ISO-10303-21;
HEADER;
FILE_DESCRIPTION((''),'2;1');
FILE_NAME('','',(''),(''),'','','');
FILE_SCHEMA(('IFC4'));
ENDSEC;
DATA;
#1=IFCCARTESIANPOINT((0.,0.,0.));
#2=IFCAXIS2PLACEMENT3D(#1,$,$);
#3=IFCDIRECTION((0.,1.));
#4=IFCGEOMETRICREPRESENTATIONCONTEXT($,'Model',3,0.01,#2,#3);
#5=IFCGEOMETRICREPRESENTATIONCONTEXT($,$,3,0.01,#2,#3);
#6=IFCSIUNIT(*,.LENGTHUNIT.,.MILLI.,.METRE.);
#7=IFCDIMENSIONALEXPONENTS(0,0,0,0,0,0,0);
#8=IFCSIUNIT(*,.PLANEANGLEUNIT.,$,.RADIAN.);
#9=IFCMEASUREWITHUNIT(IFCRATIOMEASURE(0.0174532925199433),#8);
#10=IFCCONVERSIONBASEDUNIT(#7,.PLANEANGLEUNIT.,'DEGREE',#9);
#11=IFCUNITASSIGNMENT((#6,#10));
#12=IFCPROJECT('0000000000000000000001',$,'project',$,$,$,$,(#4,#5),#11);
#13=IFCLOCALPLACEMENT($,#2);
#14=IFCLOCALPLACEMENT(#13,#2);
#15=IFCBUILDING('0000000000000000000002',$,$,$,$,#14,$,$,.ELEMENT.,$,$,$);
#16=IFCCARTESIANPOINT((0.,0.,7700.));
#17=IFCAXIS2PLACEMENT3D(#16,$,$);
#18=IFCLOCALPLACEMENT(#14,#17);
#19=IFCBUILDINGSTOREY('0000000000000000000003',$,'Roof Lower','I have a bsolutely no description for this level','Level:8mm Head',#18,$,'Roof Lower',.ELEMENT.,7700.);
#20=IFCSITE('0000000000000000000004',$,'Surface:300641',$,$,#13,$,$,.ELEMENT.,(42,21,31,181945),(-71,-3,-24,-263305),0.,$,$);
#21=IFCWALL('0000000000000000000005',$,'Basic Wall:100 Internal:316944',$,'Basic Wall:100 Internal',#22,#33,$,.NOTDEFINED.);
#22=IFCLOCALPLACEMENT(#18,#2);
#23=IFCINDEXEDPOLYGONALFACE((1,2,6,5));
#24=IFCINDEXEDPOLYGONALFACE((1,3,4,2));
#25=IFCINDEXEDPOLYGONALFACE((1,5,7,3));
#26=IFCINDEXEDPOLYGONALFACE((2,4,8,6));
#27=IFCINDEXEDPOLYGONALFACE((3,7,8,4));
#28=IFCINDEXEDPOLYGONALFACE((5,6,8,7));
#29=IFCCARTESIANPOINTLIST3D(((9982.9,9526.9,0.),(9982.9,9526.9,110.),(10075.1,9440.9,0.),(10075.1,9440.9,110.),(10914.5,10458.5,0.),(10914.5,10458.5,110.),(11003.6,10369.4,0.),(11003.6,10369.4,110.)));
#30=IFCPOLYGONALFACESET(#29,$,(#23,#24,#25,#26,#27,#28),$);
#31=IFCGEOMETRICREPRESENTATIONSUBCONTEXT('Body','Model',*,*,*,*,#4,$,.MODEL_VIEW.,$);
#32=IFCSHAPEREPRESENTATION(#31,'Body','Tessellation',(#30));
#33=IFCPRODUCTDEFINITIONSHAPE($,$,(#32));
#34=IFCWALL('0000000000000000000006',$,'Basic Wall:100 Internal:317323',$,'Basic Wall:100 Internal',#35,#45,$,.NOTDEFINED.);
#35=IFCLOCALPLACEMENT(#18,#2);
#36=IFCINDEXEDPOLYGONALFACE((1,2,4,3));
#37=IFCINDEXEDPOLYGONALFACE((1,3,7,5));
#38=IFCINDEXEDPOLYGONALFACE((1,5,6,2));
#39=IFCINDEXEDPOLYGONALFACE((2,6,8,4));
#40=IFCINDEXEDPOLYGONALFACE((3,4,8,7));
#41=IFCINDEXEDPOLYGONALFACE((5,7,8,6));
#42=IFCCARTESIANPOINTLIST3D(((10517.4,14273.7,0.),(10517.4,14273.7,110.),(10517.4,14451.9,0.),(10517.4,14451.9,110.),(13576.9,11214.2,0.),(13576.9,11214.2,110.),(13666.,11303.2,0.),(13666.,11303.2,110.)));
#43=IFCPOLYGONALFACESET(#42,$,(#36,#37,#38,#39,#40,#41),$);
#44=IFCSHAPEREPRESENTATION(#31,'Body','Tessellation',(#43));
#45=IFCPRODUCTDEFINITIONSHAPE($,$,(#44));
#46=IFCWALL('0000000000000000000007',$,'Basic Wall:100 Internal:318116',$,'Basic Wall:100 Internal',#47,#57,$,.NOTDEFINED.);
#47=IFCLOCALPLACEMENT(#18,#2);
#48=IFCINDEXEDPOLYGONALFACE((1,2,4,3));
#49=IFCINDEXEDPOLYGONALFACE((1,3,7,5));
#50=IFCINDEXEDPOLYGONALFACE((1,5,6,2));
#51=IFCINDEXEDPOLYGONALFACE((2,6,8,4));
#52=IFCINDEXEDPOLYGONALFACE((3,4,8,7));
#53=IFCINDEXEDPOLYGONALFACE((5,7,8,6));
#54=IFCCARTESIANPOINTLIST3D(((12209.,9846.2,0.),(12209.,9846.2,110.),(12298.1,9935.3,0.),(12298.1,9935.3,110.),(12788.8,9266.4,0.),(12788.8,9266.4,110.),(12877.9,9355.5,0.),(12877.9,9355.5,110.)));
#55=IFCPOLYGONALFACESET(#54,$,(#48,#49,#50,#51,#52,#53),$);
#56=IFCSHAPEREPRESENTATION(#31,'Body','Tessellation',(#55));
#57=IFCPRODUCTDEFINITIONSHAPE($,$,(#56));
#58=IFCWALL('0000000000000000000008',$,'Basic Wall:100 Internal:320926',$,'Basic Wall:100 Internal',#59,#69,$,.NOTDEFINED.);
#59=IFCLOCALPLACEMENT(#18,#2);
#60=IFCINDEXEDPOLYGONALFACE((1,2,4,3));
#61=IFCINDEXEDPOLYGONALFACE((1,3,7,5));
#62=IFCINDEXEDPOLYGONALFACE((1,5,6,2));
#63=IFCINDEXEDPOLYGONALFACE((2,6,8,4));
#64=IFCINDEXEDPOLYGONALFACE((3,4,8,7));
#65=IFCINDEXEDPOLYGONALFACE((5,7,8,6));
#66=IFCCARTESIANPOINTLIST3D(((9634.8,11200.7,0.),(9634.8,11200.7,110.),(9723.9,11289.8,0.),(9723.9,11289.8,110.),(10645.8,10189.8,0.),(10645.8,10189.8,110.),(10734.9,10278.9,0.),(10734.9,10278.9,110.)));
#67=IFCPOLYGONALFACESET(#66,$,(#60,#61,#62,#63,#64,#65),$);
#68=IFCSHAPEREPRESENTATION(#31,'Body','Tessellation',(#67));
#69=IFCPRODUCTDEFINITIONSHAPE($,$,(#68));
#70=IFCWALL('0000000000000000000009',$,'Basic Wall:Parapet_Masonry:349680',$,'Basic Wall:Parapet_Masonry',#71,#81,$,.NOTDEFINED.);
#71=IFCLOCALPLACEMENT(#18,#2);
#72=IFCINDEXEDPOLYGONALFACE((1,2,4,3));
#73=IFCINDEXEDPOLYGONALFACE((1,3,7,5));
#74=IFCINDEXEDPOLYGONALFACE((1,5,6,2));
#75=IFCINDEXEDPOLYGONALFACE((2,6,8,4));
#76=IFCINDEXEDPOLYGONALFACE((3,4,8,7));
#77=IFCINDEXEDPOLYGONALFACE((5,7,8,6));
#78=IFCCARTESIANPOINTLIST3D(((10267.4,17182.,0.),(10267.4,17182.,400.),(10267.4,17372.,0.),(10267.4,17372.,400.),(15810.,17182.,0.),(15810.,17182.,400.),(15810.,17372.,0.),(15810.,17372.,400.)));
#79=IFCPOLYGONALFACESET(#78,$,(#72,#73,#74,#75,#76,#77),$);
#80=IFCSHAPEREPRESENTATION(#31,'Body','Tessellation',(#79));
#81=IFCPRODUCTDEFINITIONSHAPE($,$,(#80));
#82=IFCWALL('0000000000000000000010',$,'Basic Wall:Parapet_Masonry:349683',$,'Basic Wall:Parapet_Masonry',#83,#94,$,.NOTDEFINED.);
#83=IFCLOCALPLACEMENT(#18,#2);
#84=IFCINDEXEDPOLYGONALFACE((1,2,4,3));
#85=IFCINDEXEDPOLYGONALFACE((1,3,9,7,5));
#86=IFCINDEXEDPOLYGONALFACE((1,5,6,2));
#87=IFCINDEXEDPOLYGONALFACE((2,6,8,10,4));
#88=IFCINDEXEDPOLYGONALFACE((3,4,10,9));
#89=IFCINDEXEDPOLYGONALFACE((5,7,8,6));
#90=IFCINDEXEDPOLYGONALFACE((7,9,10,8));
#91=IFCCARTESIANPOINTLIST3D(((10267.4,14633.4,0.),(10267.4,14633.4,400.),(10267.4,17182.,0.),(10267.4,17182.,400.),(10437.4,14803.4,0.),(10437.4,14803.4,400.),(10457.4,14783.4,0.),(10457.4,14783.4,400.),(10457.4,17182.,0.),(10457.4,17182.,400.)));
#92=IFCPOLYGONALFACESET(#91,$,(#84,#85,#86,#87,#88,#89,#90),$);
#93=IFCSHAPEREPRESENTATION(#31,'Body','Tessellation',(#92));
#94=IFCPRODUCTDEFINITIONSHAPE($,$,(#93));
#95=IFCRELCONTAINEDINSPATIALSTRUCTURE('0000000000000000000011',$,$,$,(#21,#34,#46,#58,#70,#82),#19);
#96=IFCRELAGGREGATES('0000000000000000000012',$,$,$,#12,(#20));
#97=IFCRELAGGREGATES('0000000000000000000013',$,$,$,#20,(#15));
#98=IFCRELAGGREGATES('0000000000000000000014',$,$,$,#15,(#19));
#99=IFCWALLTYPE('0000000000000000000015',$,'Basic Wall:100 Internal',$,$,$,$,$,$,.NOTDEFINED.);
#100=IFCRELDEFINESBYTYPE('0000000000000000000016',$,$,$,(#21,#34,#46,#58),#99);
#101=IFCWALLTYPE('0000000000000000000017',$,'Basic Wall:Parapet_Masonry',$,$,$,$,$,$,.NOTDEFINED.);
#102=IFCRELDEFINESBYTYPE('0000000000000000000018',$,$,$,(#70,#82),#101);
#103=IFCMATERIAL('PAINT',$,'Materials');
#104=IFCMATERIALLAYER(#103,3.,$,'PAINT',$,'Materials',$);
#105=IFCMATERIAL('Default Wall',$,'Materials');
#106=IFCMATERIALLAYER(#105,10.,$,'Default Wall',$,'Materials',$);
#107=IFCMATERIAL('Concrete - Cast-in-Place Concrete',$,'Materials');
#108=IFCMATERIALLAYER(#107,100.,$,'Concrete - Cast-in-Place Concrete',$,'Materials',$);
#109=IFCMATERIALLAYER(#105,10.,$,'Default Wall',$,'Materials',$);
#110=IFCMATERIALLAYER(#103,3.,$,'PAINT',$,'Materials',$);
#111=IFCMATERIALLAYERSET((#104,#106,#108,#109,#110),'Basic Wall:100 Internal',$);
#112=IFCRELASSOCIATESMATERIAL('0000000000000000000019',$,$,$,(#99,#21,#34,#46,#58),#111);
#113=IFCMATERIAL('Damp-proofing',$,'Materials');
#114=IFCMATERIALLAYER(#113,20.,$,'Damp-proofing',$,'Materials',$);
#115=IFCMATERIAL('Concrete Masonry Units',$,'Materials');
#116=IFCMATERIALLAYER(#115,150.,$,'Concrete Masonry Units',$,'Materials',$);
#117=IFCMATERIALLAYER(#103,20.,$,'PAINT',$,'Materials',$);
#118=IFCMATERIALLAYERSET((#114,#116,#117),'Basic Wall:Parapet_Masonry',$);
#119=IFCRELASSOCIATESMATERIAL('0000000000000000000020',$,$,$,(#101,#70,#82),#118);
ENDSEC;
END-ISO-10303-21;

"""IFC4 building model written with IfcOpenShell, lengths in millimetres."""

from ifc_helpers import new_model, entity, si_unit, converted_unit, direction, frame, frame_2d, origin, place, context, subcontext, project, spatial, polyline, rectangle, outline, extrude, clip, halfspace, bounded_halfspace, material, layer, layer_set, layer_usage, type_object, element, save


model = new_model("IFC4")

# Units and contexts
model_context = context("Model", 3, precision=0.01, world=origin(), true_north=direction((0.0, 1.0)))
context_of_model = context(None, 3, precision=0.01, world=origin(), true_north=direction((0.0, 1.0)))
body_context = subcontext(model_context, "Body", "Model", "MODEL_VIEW")
ifc_project = project(units=[si_unit("LENGTHUNIT", "METRE", prefix="MILLI"), converted_unit("PLANEANGLEUNIT", "DEGREE", entity("IfcRatioMeasure", 0.0174532925199433), si_unit("PLANEANGLEUNIT", "RADIAN"), dimensions=[0, 0, 0, 0, 0, 0, 0])], contexts=[model_context, context_of_model])

# Site, building, storey
site_placement = place(None, origin())
site = spatial("IfcSite", under=ifc_project, at=site_placement, Name="Surface:300641", CompositionType="ELEMENT", RefLatitude=(42, 21, 31, 181945), RefLongitude=(-71, -3, -24, -263305), RefElevation=0.0)
building_placement = place(site_placement, origin())
building = spatial("IfcBuilding", under=site, at=building_placement, CompositionType="ELEMENT")
storey_placement = place(building_placement, frame((0.0, 0.0, 7700.0)))
storey = spatial("IfcBuildingStorey", under=building, at=storey_placement, Name="Roof Lower", Description="I have a bsolutely no description for this level", ObjectType="Level:8mm Head", LongName="Roof Lower", CompositionType="ELEMENT", Elevation=7700.0)

# Shared definitions
ifc_material_1 = material(Name="Concrete - Cast-in-Place Concrete", Category="Materials")

# Walls
ifc_material_2 = material(Name="PAINT", Category="Materials")
ifc_material_3 = material(Name="Default Wall", Category="Materials")
ifc_layer_1 = layer(ifc_material_2, 3.0, Name="PAINT", Category="Materials")
ifc_layer_2 = layer(ifc_material_3, 10.0, Name="Default Wall", Category="Materials")
ifc_layer_3 = layer(ifc_material_1, 100.0, Name="Concrete - Cast-in-Place Concrete", Category="Materials")
ifc_layer_4 = layer(ifc_material_3, 10.0, Name="Default Wall", Category="Materials")
ifc_layer_5 = layer(ifc_material_2, 3.0, Name="PAINT", Category="Materials")
ifc_layer_set_1 = layer_set([ifc_layer_1, ifc_layer_2, ifc_layer_3, ifc_layer_4, ifc_layer_5], Name="Basic Wall:100 Internal")
wall_type_1 = type_object("IfcWallType", Name="Basic Wall:100 Internal", PredefinedType="NOTDEFINED", material=ifc_layer_set_1)
ifc_layer_usage_1 = layer_usage(ifc_layer_set_1, "AXIS2", "NEGATIVE", 63.0)
wall_1_placement = place(storey_placement, frame((10959.0, 10413.9, 0.0), z_axis=(0.0, 0.0, 1.0), x_axis=(-0.707107, -0.707107, 0.0)))
element("IfcWall", 1, at=wall_1_placement, inside=storey, type_object=wall_type_1, material=ifc_layer_usage_1, Name="Basic Wall:100 Internal:316944", ObjectType="Basic Wall:100 Internal", PredefinedType="NOTDEFINED", context=body_context, shape_type="Clipping", body=[
    clip(clip(extrude(outline(polyline([(0.0, -63.0), (254.0, -63.0), (380.0, -63.0), (1317.4, -63.0), (1313.0, 63.0), (0.0, 63.0), (0.0, -63.0)])), origin(), (0.0, 0.0, 1.0), 110.0), bounded_halfspace(frame((0.0, -63.0, 110.0), z_axis=(0.0, 0.0, -1.0), x_axis=(-0.707107, 0.707107, 0.0)), True, frame((0.0, -63.0, 110.0)), polyline([(0.0, 0.0), (254.0, 0.0), (380.0, 0.0), (1317.4, 0.0), (1313.0, 126.0), (0.0, 126.0), (0.0, 0.0)]))), halfspace(frame((0.0, 0.0, -3500.0)), True)),
])
ifc_layer_usage_2 = layer_usage(ifc_layer_set_1, "AXIS2", "NEGATIVE", 63.0)
wall_2_placement = place(storey_placement, frame((10472.8, 14407.3, 0.0), z_axis=(0.0, 0.0, 1.0), x_axis=(0.707107, -0.707107, 0.0)))
element("IfcWall", 2, at=wall_2_placement, inside=storey, type_object=wall_type_1, material=ifc_layer_usage_2, Name="Basic Wall:100 Internal:317323", ObjectType="Basic Wall:100 Internal", PredefinedType="NOTDEFINED", context=body_context, shape_type="Clipping", body=[
    clip(clip(extrude(outline(polyline([(126.0, -63.0), (1424.8, -63.0), (1674.8, -63.0), (4326.8, -63.0), (4452.8, -63.0), (4452.8, 63.0), (0.0, 63.0), (126.0, -63.0)])), origin(), (0.0, 0.0, 1.0), 110.0), bounded_halfspace(frame((126.0, -63.0, 110.0), z_axis=(0.0, 0.0, -1.0), x_axis=(0.707107, 0.707107, 0.0)), True, frame((126.0, -63.0, 110.0)), polyline([(0.0, 0.0), (1298.8, 0.0), (1548.8, 0.0), (4200.8, 0.0), (4326.8, 0.0), (4326.8, 126.0), (-126.0, 126.0), (0.0, 0.0)]))), halfspace(frame((0.0, 0.0, -3500.0)), True)),
])
ifc_layer_usage_3 = layer_usage(ifc_layer_set_1, "AXIS2", "NEGATIVE", 63.0)
wall_3_placement = place(storey_placement, frame((12253.5, 9890.7, 0.0), z_axis=(0.0, 0.0, 1.0), x_axis=(0.707107, -0.707107, 0.0)))
element("IfcWall", 3, at=wall_3_placement, inside=storey, type_object=wall_type_1, material=ifc_layer_usage_3, Name="Basic Wall:100 Internal:318116", ObjectType="Basic Wall:100 Internal", PredefinedType="NOTDEFINED", context=body_context, shape_type="Clipping", body=[
    clip(clip(extrude(rectangle(XDim=820.0, YDim=126.0, at=frame_2d((410.0, 0.0), x_axis=(-1.0, 0.0))), origin(), (0.0, 0.0, 1.0), 110.0), bounded_halfspace(frame((0.0, -63.0, 110.0), z_axis=(0.0, 0.0, -1.0), x_axis=(0.707107, 0.707107, 0.0)), True, frame((0.0, -63.0, 110.0)), polyline([(0.0, 0.0), (694.0, 0.0), (820.0, 0.0), (820.0, 126.0), (0.0, 126.0), (0.0, 0.0)]))), halfspace(frame((0.0, 0.0, -3500.0)), True)),
])
ifc_layer_usage_4 = layer_usage(ifc_layer_set_1, "AXIS2", "NEGATIVE", 63.0)
wall_4_placement = place(storey_placement, frame((10690.3, 10234.3, 0.0), z_axis=(0.0, 0.0, 1.0), x_axis=(-0.707107, 0.707107, 0.0)))
element("IfcWall", 4, at=wall_4_placement, inside=storey, type_object=wall_type_1, material=ifc_layer_usage_4, Name="Basic Wall:100 Internal:320926", ObjectType="Basic Wall:100 Internal", PredefinedType="NOTDEFINED", context=body_context, shape_type="Clipping", body=[
    clip(clip(extrude(rectangle(XDim=1429.7, YDim=126.0, at=frame_2d((714.9, 0.0), x_axis=(-1.0, 0.0))), origin(), (0.0, 0.0, 1.0), 110.0), bounded_halfspace(frame((0.0, -63.0, 110.0), z_axis=(0.0, 0.0, -1.0), x_axis=(-0.707107, -0.707107, 0.0)), True, frame((0.0, -63.0, 110.0)), polyline([(0.0, 0.0), (1429.7, 0.0), (1429.7, 125.0), (1429.7, 126.0), (0.0, 126.0), (0.0, 0.0)]))), halfspace(frame((0.0, 0.0, -3500.0)), True)),
])
ifc_material_4 = material(Name="Damp-proofing", Category="Materials")
ifc_layer_6 = layer(ifc_material_4, 20.0, Name="Damp-proofing", Category="Materials")
ifc_material_5 = material(Name="Concrete Masonry Units", Category="Materials")
ifc_layer_7 = layer(ifc_material_5, 150.0, Name="Concrete Masonry Units", Category="Materials")
ifc_layer_8 = layer(ifc_material_2, 20.0, Name="PAINT", Category="Materials")
ifc_layer_set_2 = layer_set([ifc_layer_6, ifc_layer_7, ifc_layer_8], Name="Basic Wall:Parapet_Masonry")
ifc_layer_usage_5 = layer_usage(ifc_layer_set_2, "AXIS2", "NEGATIVE", 95.0)
wall_type_2 = type_object("IfcWallType", Name="Basic Wall:Parapet_Masonry", PredefinedType="NOTDEFINED", material=ifc_layer_set_2)
wall_5_placement = place(storey_placement, frame((15810.0, 17277.0, 0.0), z_axis=(0.0, 0.0, 1.0), x_axis=(-1.0, 0.0, 0.0)))
element("IfcWall", 5, at=wall_5_placement, inside=storey, type_object=wall_type_2, material=ifc_layer_usage_5, Name="Basic Wall:Parapet_Masonry:349680", ObjectType="Basic Wall:Parapet_Masonry", PredefinedType="NOTDEFINED", context=body_context, shape_type="Clipping", body=[
    clip(extrude(rectangle(XDim=5542.6, YDim=190.0, at=frame_2d((2771.3, 0.0), x_axis=(-1.0, 0.0))), origin(), (0.0, 0.0, 1.0), 400.0), halfspace(origin(), True)),
])
ifc_layer_usage_6 = layer_usage(ifc_layer_set_2, "AXIS2", "NEGATIVE", 95.0)
wall_6_placement = place(storey_placement, frame((10362.4, 17182.0, 0.0), z_axis=(0.0, 0.0, 1.0), x_axis=(0.0, -1.0, 0.0)))
element("IfcWall", 6, at=wall_6_placement, inside=storey, type_object=wall_type_2, material=ifc_layer_usage_6, Name="Basic Wall:Parapet_Masonry:349683", ObjectType="Basic Wall:Parapet_Masonry", PredefinedType="NOTDEFINED", context=body_context, shape_type="Clipping", body=[
    clip(extrude(outline(polyline([(2548.6, -95.0), (2378.6, 75.0), (2398.6, 95.0), (0.0, 95.0), (0.0, -95.0), (2548.6, -95.0)])), origin(), (0.0, 0.0, 1.0), 400.0), halfspace(origin(), True)),
])

save(model, "model.ifc")
